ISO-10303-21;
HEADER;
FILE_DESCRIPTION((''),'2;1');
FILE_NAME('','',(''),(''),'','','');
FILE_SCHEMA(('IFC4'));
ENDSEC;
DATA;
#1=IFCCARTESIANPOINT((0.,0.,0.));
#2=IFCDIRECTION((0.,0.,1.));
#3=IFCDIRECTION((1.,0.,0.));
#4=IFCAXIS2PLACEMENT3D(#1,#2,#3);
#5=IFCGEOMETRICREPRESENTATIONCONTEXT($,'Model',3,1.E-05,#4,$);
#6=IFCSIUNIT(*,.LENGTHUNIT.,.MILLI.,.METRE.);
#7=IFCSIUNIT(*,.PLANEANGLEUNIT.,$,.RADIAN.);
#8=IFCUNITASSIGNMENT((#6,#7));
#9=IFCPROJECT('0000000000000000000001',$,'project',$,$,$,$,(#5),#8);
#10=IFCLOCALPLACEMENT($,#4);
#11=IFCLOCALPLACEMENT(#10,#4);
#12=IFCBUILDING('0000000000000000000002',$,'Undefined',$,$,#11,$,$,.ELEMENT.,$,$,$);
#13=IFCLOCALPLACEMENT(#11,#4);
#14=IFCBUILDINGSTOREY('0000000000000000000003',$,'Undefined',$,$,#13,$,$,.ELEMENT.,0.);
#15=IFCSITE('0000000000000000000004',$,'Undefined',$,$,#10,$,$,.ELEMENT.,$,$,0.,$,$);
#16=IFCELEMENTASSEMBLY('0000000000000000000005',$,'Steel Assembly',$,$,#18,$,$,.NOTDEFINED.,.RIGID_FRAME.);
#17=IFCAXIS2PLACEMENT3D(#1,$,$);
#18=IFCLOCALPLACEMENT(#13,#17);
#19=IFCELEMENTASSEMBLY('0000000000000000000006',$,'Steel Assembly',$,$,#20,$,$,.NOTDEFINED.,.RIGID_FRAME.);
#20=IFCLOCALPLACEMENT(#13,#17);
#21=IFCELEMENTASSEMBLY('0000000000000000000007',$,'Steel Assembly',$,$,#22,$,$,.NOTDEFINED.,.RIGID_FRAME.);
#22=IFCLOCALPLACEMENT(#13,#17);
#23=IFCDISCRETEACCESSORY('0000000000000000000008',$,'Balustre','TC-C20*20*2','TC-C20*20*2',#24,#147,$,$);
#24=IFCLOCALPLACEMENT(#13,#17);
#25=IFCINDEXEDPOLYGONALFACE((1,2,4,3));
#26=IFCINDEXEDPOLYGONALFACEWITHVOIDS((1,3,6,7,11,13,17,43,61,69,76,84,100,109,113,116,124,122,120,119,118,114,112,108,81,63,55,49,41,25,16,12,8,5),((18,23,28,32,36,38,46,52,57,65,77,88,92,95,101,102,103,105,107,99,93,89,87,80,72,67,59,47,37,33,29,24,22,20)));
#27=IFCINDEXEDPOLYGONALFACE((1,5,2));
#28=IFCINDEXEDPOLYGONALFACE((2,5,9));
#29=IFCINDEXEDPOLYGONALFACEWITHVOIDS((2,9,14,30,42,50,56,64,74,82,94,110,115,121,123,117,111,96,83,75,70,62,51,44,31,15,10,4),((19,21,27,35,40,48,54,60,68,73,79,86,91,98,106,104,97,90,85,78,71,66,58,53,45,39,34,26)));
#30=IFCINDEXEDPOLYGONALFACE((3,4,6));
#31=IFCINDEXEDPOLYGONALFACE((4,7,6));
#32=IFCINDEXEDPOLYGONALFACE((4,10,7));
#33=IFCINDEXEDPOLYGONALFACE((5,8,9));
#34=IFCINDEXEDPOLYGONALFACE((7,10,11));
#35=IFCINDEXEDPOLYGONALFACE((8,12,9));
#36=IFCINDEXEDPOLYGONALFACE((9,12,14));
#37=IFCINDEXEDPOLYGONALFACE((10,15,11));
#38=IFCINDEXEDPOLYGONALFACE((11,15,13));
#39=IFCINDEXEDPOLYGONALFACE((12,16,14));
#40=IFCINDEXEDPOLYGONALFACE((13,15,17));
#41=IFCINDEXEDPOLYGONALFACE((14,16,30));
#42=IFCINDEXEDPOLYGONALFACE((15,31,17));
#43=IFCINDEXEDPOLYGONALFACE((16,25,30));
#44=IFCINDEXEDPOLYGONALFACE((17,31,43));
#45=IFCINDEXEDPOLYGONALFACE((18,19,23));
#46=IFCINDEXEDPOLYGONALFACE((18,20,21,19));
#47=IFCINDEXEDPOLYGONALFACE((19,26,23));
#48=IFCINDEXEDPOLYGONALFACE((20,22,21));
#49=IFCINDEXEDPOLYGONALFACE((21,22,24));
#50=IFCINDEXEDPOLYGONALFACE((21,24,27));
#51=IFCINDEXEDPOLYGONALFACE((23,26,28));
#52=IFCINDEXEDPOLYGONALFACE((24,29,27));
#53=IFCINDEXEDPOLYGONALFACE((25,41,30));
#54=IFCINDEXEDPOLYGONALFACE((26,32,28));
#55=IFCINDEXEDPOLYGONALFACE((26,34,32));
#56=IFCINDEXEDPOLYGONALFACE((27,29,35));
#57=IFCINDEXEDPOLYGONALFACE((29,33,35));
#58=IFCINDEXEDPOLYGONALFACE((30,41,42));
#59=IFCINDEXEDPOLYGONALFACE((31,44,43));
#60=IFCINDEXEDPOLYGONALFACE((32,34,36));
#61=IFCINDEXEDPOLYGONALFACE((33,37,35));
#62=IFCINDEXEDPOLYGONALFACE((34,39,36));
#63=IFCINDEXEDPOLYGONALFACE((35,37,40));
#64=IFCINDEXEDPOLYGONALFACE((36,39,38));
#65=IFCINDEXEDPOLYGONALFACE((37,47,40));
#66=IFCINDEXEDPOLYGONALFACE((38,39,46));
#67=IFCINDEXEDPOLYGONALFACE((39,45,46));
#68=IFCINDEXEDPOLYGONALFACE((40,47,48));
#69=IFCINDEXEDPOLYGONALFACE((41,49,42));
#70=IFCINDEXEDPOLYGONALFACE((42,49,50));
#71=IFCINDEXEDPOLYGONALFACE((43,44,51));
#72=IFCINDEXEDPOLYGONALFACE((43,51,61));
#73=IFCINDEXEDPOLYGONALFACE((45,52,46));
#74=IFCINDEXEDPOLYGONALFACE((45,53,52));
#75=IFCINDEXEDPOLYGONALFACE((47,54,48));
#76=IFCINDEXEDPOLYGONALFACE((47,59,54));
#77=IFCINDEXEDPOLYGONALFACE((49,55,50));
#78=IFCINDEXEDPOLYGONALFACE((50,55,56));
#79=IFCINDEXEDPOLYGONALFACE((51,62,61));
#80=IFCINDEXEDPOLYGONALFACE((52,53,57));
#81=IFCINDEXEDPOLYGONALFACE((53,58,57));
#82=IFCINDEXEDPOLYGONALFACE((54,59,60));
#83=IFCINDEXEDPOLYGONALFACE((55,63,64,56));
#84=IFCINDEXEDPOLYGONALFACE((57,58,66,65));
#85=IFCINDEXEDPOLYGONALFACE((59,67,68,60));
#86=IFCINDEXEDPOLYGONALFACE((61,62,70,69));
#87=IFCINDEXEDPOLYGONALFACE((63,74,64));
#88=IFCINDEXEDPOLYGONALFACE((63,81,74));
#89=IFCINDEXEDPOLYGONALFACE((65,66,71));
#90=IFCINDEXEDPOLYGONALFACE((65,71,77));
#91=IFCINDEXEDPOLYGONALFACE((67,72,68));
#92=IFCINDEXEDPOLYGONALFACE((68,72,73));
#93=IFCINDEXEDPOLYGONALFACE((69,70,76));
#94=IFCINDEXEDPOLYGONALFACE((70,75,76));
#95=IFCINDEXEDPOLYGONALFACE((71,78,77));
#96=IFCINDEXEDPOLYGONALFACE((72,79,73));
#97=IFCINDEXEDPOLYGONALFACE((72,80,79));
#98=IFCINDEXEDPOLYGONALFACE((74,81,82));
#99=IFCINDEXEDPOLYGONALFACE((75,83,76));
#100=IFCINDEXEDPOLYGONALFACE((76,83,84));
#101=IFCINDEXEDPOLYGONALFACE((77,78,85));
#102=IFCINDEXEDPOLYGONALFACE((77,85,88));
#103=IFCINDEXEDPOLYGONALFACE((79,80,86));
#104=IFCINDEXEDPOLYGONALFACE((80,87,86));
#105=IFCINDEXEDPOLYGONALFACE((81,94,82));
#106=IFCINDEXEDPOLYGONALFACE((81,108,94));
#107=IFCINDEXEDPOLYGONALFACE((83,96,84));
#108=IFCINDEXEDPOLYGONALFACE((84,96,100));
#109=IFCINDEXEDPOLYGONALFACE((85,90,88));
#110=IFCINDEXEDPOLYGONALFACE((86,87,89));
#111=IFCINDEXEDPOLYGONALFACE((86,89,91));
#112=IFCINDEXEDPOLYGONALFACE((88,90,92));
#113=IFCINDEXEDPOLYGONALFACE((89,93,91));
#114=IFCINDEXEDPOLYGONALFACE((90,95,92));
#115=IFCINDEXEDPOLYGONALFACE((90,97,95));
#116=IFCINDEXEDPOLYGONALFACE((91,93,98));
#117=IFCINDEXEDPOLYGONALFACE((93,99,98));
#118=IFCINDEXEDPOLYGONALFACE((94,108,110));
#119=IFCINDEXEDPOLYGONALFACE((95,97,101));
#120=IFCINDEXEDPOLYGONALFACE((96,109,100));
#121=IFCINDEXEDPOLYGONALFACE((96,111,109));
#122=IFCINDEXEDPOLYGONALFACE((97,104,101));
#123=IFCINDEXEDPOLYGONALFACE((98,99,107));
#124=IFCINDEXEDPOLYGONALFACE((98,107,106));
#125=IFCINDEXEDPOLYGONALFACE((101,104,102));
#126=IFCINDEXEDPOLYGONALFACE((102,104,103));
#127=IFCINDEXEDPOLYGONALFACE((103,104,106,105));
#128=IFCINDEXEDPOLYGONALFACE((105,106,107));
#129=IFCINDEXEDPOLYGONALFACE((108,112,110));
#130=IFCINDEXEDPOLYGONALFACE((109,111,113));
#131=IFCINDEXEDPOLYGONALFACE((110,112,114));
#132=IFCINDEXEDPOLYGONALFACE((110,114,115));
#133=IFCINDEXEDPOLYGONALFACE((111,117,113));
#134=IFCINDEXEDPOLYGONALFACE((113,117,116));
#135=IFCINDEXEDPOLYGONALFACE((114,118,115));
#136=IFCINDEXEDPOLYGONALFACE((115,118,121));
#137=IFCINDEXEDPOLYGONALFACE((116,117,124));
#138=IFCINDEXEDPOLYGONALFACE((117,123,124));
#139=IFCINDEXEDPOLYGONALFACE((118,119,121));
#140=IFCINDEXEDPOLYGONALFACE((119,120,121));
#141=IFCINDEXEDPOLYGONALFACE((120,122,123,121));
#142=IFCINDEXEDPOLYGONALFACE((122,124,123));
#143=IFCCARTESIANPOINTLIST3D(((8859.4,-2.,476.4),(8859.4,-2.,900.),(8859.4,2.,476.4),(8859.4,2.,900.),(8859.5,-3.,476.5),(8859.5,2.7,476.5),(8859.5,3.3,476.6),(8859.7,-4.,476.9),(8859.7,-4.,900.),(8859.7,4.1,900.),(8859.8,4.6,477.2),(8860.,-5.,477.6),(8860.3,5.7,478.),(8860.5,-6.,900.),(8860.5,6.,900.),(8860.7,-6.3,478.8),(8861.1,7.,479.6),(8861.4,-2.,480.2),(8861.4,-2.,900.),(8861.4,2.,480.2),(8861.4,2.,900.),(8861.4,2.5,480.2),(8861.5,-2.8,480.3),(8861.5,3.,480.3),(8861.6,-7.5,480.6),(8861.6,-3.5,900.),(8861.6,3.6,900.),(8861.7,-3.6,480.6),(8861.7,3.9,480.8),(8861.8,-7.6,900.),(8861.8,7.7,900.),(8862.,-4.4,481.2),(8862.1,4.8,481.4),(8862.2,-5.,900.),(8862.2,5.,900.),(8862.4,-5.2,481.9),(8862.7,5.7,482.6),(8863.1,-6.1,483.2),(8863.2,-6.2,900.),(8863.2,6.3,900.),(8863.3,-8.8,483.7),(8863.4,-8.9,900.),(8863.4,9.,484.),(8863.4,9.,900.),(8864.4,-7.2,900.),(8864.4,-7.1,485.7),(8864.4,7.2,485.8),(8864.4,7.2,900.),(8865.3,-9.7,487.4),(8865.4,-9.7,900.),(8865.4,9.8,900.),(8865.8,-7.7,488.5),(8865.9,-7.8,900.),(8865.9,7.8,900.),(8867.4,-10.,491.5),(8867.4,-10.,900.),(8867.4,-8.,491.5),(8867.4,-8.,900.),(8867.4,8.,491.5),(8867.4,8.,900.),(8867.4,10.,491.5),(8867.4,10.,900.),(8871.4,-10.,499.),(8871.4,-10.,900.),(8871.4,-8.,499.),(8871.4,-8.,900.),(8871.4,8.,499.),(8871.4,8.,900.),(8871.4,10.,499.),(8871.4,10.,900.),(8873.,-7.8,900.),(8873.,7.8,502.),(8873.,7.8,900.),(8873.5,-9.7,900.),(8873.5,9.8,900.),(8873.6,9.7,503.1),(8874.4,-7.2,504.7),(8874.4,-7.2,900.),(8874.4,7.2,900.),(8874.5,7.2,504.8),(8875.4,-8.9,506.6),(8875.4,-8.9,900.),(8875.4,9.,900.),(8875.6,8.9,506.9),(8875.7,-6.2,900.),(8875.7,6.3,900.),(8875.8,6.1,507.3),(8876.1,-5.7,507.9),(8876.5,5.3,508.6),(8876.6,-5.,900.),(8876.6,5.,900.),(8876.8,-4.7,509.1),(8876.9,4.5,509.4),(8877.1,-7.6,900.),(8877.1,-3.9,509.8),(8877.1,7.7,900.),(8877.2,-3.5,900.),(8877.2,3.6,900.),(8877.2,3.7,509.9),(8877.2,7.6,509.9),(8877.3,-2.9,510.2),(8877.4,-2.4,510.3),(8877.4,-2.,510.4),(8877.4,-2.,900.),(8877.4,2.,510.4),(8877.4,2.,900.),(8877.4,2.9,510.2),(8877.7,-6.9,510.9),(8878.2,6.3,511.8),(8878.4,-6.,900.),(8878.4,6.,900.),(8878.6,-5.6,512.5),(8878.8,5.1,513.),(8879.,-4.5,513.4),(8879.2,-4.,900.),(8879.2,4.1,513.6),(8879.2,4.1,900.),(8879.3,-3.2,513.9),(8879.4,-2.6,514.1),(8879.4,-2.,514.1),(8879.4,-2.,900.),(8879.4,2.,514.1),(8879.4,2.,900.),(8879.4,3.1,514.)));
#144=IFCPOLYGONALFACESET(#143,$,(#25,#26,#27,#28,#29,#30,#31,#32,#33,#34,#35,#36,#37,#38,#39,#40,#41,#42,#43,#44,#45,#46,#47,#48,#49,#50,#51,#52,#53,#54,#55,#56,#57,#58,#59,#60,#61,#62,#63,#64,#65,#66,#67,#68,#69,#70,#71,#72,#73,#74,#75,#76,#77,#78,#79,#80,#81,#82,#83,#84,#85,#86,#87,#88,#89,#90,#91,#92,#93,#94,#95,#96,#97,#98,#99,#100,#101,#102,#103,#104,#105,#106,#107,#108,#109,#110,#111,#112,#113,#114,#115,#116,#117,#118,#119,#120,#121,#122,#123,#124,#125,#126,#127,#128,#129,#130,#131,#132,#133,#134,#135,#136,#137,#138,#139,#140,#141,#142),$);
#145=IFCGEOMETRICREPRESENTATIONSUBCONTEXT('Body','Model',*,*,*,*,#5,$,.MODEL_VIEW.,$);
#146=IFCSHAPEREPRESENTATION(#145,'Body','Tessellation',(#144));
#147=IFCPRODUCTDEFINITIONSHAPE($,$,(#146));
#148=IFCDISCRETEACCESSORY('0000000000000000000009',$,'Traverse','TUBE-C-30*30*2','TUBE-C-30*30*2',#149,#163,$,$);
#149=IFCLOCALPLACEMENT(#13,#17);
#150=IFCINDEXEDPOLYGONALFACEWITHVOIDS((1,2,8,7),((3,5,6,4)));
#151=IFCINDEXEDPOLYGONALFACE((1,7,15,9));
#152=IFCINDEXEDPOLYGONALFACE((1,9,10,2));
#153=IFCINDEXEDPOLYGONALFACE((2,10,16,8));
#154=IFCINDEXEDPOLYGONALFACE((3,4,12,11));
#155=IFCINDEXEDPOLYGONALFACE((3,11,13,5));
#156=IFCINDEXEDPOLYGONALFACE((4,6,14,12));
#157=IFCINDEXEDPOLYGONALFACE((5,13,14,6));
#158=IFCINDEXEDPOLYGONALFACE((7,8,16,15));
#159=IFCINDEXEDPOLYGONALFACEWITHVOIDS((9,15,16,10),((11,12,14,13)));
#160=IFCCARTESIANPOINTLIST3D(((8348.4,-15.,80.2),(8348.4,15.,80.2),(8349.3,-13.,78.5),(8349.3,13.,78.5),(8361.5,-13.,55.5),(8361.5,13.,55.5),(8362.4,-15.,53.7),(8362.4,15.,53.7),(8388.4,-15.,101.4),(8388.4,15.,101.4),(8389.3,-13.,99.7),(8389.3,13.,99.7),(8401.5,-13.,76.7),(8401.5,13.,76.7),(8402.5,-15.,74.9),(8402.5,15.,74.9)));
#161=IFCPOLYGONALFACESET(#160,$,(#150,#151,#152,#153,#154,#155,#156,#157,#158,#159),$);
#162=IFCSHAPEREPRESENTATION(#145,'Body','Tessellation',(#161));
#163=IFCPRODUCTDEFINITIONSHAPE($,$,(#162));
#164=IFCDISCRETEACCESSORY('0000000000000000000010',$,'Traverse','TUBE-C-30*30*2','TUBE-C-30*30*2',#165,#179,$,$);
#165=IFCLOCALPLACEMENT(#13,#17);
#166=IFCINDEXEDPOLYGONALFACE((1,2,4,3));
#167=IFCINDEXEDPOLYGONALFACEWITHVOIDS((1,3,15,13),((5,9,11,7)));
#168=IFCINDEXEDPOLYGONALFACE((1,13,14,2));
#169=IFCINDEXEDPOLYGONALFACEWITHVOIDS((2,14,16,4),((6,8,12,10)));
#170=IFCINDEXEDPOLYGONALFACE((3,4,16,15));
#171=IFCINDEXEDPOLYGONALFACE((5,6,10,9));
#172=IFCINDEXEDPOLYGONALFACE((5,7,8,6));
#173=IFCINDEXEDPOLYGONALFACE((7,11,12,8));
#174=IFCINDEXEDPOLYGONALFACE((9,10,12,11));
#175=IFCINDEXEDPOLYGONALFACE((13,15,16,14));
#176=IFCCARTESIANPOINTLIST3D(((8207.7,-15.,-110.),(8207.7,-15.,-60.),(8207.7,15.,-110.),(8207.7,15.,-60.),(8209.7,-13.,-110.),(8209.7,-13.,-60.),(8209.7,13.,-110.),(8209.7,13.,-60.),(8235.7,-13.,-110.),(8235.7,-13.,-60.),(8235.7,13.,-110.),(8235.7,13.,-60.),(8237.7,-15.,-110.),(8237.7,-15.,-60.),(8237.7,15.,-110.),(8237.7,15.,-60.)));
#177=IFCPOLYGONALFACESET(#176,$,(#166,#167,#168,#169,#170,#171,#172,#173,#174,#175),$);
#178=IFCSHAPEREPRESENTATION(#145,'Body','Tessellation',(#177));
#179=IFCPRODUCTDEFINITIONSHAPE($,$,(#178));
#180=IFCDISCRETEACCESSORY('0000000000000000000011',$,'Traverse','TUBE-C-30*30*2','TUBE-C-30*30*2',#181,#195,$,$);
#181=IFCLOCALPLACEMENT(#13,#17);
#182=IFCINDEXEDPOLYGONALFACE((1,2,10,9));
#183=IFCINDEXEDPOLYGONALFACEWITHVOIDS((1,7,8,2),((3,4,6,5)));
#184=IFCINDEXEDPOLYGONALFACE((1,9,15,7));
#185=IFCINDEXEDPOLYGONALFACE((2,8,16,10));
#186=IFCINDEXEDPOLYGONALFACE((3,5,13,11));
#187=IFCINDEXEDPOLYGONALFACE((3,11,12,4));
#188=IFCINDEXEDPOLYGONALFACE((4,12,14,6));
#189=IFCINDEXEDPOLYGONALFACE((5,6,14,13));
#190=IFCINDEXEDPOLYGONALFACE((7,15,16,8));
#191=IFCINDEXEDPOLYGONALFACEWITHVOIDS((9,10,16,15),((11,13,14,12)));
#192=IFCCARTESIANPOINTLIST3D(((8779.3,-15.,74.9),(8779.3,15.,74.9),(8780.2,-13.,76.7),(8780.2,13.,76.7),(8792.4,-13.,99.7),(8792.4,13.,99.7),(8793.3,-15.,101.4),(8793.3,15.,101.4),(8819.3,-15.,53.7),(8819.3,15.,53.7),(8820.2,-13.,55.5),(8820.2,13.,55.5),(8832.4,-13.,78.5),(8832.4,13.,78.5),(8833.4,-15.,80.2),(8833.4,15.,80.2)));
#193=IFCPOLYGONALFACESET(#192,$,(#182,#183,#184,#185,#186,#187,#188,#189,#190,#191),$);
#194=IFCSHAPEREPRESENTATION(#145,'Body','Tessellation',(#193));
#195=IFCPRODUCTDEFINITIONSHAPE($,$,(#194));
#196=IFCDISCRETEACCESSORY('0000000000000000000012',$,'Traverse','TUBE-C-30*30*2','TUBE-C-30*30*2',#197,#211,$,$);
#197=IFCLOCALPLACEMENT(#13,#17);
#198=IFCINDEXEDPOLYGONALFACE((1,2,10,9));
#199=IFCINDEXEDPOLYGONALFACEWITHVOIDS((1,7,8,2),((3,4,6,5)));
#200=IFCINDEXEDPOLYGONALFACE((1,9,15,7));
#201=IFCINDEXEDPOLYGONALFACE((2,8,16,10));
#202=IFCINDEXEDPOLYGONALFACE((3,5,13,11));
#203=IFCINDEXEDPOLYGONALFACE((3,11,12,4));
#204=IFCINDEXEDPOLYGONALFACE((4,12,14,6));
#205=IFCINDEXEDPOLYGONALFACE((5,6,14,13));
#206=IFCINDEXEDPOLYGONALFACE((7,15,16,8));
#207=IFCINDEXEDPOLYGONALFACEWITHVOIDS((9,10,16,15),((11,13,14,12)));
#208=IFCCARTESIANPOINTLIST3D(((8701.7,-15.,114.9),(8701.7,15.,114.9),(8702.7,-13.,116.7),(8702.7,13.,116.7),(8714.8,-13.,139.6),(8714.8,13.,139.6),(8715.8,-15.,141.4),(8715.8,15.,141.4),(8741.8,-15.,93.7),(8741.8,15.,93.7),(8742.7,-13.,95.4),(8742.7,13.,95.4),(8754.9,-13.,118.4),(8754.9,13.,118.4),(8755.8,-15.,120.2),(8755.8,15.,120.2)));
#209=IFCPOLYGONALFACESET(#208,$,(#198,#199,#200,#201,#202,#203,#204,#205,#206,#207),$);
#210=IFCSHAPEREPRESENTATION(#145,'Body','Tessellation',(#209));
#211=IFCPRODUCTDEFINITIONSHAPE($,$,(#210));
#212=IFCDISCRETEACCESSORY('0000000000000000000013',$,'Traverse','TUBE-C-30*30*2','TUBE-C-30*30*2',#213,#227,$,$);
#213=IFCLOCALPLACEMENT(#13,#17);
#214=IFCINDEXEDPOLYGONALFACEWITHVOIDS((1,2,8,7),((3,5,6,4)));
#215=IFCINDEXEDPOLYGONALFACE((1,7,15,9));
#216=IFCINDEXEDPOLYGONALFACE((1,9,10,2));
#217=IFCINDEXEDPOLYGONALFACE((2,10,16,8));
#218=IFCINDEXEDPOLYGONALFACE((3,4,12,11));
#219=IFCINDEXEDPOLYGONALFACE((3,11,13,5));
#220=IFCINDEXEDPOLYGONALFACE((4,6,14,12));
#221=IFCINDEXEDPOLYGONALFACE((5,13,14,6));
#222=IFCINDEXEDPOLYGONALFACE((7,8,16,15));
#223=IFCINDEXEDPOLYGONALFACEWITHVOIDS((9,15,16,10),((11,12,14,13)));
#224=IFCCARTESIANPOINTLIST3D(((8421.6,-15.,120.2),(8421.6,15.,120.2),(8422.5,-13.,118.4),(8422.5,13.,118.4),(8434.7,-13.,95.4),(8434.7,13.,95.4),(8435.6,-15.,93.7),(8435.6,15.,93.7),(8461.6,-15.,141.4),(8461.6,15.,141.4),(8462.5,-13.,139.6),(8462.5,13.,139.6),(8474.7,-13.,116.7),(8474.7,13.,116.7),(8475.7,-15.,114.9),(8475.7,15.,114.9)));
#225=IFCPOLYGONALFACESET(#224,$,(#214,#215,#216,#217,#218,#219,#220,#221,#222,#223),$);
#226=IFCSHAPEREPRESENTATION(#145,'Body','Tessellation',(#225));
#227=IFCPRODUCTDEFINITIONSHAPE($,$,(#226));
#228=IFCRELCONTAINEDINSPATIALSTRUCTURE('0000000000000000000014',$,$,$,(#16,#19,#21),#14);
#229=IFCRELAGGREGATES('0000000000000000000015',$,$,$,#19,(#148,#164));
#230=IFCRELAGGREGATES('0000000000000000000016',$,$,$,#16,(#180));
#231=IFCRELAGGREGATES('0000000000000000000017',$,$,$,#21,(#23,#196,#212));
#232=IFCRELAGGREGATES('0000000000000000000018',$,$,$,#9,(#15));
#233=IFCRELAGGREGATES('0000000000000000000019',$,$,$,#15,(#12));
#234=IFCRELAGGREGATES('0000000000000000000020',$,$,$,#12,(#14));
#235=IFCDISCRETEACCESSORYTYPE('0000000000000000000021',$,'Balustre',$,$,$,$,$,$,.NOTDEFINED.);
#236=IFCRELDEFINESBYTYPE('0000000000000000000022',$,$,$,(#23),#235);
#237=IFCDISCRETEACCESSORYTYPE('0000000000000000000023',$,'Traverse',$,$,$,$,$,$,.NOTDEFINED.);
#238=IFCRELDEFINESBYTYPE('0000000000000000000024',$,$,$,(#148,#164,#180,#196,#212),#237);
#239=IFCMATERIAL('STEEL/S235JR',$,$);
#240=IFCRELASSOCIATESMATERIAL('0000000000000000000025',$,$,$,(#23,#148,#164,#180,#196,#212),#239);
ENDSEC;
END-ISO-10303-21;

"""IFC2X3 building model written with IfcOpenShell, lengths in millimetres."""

from ifc_helpers import new_model, si_unit, frame, origin_with_axes, origin_2d_with_axis, place, context, subcontext, project, spatial, hollow_rectangle, extrude, clip, halfspace, material, type_object, element, aggregate, save


model = new_model("IFC2X3")

# Units and contexts
model_context = context("Model", 3, precision=1e-05, world=origin_with_axes())
body_context = subcontext(model_context, "Body", "Model", "MODEL_VIEW")
ifc_project = project(units=[si_unit("LENGTHUNIT", "METRE", prefix="MILLI"), si_unit("PLANEANGLEUNIT", "RADIAN")], contexts=[model_context])

# Site, building, storey
site_placement = place(None, origin_with_axes())
site = spatial("IfcSite", under=ifc_project, at=site_placement, Name="Undefined", CompositionType="ELEMENT", RefElevation=0.0)
building_placement = place(site_placement, origin_with_axes())
building = spatial("IfcBuilding", under=site, at=building_placement, Name="Undefined", CompositionType="ELEMENT")
storey_placement = place(building_placement, origin_with_axes())
storey = spatial("IfcBuildingStorey", under=building, at=storey_placement, Name="Undefined", CompositionType="ELEMENT", Elevation=0.0)

# Element assembly
assembly_1_placement = place(storey_placement, origin_with_axes())
assembly_1 = element("IfcElementAssembly", 1, at=assembly_1_placement, inside=storey, Name="Steel Assembly", AssemblyPlace="NOTDEFINED", PredefinedType="RIGID_FRAME")
ifc_material = material(Name="STEEL/S235JR")

# Element assembly
assembly_2_placement = place(storey_placement, origin_with_axes())
assembly_2 = element("IfcElementAssembly", 2, at=assembly_2_placement, inside=storey, Name="Steel Assembly", AssemblyPlace="NOTDEFINED", PredefinedType="RIGID_FRAME")
discrete_accessory_type_1 = type_object("IfcDiscreteAccessoryType", Name="Balustre")

# Element assembly, discrete accessory
assembly_3_placement = place(storey_placement, origin_with_axes())
assembly_3 = element("IfcElementAssembly", 3, at=assembly_3_placement, inside=storey, Name="Steel Assembly", AssemblyPlace="NOTDEFINED", PredefinedType="RIGID_FRAME")
discrete_accessory_1_placement = place(assembly_3_placement, frame((8869.4, 0.0, 900.0), z_axis=(-0.000011, 1.0, 0.0), x_axis=(0.0, 0.0, -1.0)))
discrete_accessory_1 = element("IfcDiscreteAccessory", 4, at=discrete_accessory_1_placement, type_object=discrete_accessory_type_1, material=ifc_material, Name="Balustre", Description="TC-C20*20*2", ObjectType="TC-C20*20*2", context=body_context, shape_type="Clipping", body=[
    clip(extrude(hollow_rectangle(XDim=20.0, YDim=20.0, WallThickness=2.0, InnerFilletRadius=6.0, OuterFilletRadius=8.0, at=origin_2d_with_axis()), frame((423.8, 0.0, 0.0), z_axis=(-1.0, 0.0, 0.0), x_axis=(0.0, -1.0, 0.0)), (0.0, 0.0, 1.0), 423.8), halfspace(frame((429.9, 13.3, 0.0), z_axis=(-0.46842, 0.883506, 0.000005), x_axis=(0.0, -0.000005, 1.0)), True)),
])

# Discrete accessories
discrete_accessory_type_2 = type_object("IfcDiscreteAccessoryType", Name="Traverse")
discrete_accessory_2_placement = place(assembly_2_placement, frame((8355.4, 0.0, 67.0), z_axis=(-0.000011, 1.0, 0.0), x_axis=(0.883506, 0.00001, 0.46842)))
discrete_accessory_2 = element("IfcDiscreteAccessory", 5, at=discrete_accessory_2_placement, type_object=discrete_accessory_type_2, material=ifc_material, Name="Traverse", Description="TUBE-C-30*30*2", ObjectType="TUBE-C-30*30*2", context=body_context, shape_type="SweptSolid", body=[
    extrude(hollow_rectangle(XDim=30.0, YDim=30.0, WallThickness=2.0, at=origin_2d_with_axis()), frame((45.3, 0.0, 0.0), z_axis=(-1.0, 0.0, 0.0), x_axis=(0.0, -1.0, 0.0)), (0.0, 0.0, 1.0), 45.3),
])
discrete_accessory_3_placement = place(assembly_2_placement, frame((8222.7, 0.0, -60.0), z_axis=(-0.000011, 1.0, 0.0), x_axis=(0.0, 0.0, -1.0)))
discrete_accessory_3 = element("IfcDiscreteAccessory", 6, at=discrete_accessory_3_placement, type_object=discrete_accessory_type_2, material=ifc_material, Name="Traverse", Description="TUBE-C-30*30*2", ObjectType="TUBE-C-30*30*2", context=body_context, shape_type="SweptSolid", body=[
    extrude(hollow_rectangle(XDim=30.0, YDim=30.0, WallThickness=2.0, at=origin_2d_with_axis()), frame((50.0, 0.0, 0.0), z_axis=(-1.0, 0.0, 0.0), x_axis=(0.0, -1.0, 0.0)), (0.0, 0.0, 1.0), 50.0),
])
aggregate(assembly_2, [discrete_accessory_2, discrete_accessory_3])
discrete_accessory_4_placement = place(assembly_1_placement, frame((8826.3, 0.0, 67.0), z_axis=(-0.000011, 1.0, 0.0), x_axis=(-0.883506, -0.00001, 0.46842)))
discrete_accessory_4 = element("IfcDiscreteAccessory", 7, at=discrete_accessory_4_placement, type_object=discrete_accessory_type_2, material=ifc_material, Name="Traverse", Description="TUBE-C-30*30*2", ObjectType="TUBE-C-30*30*2", context=body_context, shape_type="SweptSolid", body=[
    extrude(hollow_rectangle(XDim=30.0, YDim=30.0, WallThickness=2.0, at=origin_2d_with_axis()), frame((45.3, 0.0, 0.0), z_axis=(-1.0, 0.0, 0.0), x_axis=(0.0, -1.0, 0.0)), (0.0, 0.0, 1.0), 45.3),
])
aggregate(assembly_1, [discrete_accessory_4])
discrete_accessory_5_placement = place(assembly_3_placement, frame((8708.8, 0.0, 128.2), z_axis=(0.0, 1.0, 0.0), x_axis=(0.883506, 0.0, -0.46842)))
discrete_accessory_5 = element("IfcDiscreteAccessory", 8, at=discrete_accessory_5_placement, type_object=discrete_accessory_type_2, material=ifc_material, Name="Traverse", Description="TUBE-C-30*30*2", ObjectType="TUBE-C-30*30*2", context=body_context, shape_type="SweptSolid", body=[
    extrude(hollow_rectangle(XDim=30.0, YDim=30.0, WallThickness=2.0, at=origin_2d_with_axis()), frame((45.3, 0.0, 0.0), z_axis=(-1.0, 0.0, 0.0), x_axis=(0.0, -1.0, 0.0)), (0.0, 0.0, 1.0), 45.3),
])
discrete_accessory_6_placement = place(assembly_3_placement, frame((8468.6, 0.0, 128.2), z_axis=(0.0, 1.0, 0.0), x_axis=(-0.883506, 0.0, -0.46842)))
discrete_accessory_6 = element("IfcDiscreteAccessory", 9, at=discrete_accessory_6_placement, type_object=discrete_accessory_type_2, material=ifc_material, Name="Traverse", Description="TUBE-C-30*30*2", ObjectType="TUBE-C-30*30*2", context=body_context, shape_type="SweptSolid", body=[
    extrude(hollow_rectangle(XDim=30.0, YDim=30.0, WallThickness=2.0, at=origin_2d_with_axis()), frame((45.3, 0.0, 0.0), z_axis=(-1.0, 0.0, 0.0), x_axis=(0.0, -1.0, 0.0)), (0.0, 0.0, 1.0), 45.3),
])
aggregate(assembly_3, [discrete_accessory_1, discrete_accessory_5, discrete_accessory_6])

save(model, "model.ifc")
